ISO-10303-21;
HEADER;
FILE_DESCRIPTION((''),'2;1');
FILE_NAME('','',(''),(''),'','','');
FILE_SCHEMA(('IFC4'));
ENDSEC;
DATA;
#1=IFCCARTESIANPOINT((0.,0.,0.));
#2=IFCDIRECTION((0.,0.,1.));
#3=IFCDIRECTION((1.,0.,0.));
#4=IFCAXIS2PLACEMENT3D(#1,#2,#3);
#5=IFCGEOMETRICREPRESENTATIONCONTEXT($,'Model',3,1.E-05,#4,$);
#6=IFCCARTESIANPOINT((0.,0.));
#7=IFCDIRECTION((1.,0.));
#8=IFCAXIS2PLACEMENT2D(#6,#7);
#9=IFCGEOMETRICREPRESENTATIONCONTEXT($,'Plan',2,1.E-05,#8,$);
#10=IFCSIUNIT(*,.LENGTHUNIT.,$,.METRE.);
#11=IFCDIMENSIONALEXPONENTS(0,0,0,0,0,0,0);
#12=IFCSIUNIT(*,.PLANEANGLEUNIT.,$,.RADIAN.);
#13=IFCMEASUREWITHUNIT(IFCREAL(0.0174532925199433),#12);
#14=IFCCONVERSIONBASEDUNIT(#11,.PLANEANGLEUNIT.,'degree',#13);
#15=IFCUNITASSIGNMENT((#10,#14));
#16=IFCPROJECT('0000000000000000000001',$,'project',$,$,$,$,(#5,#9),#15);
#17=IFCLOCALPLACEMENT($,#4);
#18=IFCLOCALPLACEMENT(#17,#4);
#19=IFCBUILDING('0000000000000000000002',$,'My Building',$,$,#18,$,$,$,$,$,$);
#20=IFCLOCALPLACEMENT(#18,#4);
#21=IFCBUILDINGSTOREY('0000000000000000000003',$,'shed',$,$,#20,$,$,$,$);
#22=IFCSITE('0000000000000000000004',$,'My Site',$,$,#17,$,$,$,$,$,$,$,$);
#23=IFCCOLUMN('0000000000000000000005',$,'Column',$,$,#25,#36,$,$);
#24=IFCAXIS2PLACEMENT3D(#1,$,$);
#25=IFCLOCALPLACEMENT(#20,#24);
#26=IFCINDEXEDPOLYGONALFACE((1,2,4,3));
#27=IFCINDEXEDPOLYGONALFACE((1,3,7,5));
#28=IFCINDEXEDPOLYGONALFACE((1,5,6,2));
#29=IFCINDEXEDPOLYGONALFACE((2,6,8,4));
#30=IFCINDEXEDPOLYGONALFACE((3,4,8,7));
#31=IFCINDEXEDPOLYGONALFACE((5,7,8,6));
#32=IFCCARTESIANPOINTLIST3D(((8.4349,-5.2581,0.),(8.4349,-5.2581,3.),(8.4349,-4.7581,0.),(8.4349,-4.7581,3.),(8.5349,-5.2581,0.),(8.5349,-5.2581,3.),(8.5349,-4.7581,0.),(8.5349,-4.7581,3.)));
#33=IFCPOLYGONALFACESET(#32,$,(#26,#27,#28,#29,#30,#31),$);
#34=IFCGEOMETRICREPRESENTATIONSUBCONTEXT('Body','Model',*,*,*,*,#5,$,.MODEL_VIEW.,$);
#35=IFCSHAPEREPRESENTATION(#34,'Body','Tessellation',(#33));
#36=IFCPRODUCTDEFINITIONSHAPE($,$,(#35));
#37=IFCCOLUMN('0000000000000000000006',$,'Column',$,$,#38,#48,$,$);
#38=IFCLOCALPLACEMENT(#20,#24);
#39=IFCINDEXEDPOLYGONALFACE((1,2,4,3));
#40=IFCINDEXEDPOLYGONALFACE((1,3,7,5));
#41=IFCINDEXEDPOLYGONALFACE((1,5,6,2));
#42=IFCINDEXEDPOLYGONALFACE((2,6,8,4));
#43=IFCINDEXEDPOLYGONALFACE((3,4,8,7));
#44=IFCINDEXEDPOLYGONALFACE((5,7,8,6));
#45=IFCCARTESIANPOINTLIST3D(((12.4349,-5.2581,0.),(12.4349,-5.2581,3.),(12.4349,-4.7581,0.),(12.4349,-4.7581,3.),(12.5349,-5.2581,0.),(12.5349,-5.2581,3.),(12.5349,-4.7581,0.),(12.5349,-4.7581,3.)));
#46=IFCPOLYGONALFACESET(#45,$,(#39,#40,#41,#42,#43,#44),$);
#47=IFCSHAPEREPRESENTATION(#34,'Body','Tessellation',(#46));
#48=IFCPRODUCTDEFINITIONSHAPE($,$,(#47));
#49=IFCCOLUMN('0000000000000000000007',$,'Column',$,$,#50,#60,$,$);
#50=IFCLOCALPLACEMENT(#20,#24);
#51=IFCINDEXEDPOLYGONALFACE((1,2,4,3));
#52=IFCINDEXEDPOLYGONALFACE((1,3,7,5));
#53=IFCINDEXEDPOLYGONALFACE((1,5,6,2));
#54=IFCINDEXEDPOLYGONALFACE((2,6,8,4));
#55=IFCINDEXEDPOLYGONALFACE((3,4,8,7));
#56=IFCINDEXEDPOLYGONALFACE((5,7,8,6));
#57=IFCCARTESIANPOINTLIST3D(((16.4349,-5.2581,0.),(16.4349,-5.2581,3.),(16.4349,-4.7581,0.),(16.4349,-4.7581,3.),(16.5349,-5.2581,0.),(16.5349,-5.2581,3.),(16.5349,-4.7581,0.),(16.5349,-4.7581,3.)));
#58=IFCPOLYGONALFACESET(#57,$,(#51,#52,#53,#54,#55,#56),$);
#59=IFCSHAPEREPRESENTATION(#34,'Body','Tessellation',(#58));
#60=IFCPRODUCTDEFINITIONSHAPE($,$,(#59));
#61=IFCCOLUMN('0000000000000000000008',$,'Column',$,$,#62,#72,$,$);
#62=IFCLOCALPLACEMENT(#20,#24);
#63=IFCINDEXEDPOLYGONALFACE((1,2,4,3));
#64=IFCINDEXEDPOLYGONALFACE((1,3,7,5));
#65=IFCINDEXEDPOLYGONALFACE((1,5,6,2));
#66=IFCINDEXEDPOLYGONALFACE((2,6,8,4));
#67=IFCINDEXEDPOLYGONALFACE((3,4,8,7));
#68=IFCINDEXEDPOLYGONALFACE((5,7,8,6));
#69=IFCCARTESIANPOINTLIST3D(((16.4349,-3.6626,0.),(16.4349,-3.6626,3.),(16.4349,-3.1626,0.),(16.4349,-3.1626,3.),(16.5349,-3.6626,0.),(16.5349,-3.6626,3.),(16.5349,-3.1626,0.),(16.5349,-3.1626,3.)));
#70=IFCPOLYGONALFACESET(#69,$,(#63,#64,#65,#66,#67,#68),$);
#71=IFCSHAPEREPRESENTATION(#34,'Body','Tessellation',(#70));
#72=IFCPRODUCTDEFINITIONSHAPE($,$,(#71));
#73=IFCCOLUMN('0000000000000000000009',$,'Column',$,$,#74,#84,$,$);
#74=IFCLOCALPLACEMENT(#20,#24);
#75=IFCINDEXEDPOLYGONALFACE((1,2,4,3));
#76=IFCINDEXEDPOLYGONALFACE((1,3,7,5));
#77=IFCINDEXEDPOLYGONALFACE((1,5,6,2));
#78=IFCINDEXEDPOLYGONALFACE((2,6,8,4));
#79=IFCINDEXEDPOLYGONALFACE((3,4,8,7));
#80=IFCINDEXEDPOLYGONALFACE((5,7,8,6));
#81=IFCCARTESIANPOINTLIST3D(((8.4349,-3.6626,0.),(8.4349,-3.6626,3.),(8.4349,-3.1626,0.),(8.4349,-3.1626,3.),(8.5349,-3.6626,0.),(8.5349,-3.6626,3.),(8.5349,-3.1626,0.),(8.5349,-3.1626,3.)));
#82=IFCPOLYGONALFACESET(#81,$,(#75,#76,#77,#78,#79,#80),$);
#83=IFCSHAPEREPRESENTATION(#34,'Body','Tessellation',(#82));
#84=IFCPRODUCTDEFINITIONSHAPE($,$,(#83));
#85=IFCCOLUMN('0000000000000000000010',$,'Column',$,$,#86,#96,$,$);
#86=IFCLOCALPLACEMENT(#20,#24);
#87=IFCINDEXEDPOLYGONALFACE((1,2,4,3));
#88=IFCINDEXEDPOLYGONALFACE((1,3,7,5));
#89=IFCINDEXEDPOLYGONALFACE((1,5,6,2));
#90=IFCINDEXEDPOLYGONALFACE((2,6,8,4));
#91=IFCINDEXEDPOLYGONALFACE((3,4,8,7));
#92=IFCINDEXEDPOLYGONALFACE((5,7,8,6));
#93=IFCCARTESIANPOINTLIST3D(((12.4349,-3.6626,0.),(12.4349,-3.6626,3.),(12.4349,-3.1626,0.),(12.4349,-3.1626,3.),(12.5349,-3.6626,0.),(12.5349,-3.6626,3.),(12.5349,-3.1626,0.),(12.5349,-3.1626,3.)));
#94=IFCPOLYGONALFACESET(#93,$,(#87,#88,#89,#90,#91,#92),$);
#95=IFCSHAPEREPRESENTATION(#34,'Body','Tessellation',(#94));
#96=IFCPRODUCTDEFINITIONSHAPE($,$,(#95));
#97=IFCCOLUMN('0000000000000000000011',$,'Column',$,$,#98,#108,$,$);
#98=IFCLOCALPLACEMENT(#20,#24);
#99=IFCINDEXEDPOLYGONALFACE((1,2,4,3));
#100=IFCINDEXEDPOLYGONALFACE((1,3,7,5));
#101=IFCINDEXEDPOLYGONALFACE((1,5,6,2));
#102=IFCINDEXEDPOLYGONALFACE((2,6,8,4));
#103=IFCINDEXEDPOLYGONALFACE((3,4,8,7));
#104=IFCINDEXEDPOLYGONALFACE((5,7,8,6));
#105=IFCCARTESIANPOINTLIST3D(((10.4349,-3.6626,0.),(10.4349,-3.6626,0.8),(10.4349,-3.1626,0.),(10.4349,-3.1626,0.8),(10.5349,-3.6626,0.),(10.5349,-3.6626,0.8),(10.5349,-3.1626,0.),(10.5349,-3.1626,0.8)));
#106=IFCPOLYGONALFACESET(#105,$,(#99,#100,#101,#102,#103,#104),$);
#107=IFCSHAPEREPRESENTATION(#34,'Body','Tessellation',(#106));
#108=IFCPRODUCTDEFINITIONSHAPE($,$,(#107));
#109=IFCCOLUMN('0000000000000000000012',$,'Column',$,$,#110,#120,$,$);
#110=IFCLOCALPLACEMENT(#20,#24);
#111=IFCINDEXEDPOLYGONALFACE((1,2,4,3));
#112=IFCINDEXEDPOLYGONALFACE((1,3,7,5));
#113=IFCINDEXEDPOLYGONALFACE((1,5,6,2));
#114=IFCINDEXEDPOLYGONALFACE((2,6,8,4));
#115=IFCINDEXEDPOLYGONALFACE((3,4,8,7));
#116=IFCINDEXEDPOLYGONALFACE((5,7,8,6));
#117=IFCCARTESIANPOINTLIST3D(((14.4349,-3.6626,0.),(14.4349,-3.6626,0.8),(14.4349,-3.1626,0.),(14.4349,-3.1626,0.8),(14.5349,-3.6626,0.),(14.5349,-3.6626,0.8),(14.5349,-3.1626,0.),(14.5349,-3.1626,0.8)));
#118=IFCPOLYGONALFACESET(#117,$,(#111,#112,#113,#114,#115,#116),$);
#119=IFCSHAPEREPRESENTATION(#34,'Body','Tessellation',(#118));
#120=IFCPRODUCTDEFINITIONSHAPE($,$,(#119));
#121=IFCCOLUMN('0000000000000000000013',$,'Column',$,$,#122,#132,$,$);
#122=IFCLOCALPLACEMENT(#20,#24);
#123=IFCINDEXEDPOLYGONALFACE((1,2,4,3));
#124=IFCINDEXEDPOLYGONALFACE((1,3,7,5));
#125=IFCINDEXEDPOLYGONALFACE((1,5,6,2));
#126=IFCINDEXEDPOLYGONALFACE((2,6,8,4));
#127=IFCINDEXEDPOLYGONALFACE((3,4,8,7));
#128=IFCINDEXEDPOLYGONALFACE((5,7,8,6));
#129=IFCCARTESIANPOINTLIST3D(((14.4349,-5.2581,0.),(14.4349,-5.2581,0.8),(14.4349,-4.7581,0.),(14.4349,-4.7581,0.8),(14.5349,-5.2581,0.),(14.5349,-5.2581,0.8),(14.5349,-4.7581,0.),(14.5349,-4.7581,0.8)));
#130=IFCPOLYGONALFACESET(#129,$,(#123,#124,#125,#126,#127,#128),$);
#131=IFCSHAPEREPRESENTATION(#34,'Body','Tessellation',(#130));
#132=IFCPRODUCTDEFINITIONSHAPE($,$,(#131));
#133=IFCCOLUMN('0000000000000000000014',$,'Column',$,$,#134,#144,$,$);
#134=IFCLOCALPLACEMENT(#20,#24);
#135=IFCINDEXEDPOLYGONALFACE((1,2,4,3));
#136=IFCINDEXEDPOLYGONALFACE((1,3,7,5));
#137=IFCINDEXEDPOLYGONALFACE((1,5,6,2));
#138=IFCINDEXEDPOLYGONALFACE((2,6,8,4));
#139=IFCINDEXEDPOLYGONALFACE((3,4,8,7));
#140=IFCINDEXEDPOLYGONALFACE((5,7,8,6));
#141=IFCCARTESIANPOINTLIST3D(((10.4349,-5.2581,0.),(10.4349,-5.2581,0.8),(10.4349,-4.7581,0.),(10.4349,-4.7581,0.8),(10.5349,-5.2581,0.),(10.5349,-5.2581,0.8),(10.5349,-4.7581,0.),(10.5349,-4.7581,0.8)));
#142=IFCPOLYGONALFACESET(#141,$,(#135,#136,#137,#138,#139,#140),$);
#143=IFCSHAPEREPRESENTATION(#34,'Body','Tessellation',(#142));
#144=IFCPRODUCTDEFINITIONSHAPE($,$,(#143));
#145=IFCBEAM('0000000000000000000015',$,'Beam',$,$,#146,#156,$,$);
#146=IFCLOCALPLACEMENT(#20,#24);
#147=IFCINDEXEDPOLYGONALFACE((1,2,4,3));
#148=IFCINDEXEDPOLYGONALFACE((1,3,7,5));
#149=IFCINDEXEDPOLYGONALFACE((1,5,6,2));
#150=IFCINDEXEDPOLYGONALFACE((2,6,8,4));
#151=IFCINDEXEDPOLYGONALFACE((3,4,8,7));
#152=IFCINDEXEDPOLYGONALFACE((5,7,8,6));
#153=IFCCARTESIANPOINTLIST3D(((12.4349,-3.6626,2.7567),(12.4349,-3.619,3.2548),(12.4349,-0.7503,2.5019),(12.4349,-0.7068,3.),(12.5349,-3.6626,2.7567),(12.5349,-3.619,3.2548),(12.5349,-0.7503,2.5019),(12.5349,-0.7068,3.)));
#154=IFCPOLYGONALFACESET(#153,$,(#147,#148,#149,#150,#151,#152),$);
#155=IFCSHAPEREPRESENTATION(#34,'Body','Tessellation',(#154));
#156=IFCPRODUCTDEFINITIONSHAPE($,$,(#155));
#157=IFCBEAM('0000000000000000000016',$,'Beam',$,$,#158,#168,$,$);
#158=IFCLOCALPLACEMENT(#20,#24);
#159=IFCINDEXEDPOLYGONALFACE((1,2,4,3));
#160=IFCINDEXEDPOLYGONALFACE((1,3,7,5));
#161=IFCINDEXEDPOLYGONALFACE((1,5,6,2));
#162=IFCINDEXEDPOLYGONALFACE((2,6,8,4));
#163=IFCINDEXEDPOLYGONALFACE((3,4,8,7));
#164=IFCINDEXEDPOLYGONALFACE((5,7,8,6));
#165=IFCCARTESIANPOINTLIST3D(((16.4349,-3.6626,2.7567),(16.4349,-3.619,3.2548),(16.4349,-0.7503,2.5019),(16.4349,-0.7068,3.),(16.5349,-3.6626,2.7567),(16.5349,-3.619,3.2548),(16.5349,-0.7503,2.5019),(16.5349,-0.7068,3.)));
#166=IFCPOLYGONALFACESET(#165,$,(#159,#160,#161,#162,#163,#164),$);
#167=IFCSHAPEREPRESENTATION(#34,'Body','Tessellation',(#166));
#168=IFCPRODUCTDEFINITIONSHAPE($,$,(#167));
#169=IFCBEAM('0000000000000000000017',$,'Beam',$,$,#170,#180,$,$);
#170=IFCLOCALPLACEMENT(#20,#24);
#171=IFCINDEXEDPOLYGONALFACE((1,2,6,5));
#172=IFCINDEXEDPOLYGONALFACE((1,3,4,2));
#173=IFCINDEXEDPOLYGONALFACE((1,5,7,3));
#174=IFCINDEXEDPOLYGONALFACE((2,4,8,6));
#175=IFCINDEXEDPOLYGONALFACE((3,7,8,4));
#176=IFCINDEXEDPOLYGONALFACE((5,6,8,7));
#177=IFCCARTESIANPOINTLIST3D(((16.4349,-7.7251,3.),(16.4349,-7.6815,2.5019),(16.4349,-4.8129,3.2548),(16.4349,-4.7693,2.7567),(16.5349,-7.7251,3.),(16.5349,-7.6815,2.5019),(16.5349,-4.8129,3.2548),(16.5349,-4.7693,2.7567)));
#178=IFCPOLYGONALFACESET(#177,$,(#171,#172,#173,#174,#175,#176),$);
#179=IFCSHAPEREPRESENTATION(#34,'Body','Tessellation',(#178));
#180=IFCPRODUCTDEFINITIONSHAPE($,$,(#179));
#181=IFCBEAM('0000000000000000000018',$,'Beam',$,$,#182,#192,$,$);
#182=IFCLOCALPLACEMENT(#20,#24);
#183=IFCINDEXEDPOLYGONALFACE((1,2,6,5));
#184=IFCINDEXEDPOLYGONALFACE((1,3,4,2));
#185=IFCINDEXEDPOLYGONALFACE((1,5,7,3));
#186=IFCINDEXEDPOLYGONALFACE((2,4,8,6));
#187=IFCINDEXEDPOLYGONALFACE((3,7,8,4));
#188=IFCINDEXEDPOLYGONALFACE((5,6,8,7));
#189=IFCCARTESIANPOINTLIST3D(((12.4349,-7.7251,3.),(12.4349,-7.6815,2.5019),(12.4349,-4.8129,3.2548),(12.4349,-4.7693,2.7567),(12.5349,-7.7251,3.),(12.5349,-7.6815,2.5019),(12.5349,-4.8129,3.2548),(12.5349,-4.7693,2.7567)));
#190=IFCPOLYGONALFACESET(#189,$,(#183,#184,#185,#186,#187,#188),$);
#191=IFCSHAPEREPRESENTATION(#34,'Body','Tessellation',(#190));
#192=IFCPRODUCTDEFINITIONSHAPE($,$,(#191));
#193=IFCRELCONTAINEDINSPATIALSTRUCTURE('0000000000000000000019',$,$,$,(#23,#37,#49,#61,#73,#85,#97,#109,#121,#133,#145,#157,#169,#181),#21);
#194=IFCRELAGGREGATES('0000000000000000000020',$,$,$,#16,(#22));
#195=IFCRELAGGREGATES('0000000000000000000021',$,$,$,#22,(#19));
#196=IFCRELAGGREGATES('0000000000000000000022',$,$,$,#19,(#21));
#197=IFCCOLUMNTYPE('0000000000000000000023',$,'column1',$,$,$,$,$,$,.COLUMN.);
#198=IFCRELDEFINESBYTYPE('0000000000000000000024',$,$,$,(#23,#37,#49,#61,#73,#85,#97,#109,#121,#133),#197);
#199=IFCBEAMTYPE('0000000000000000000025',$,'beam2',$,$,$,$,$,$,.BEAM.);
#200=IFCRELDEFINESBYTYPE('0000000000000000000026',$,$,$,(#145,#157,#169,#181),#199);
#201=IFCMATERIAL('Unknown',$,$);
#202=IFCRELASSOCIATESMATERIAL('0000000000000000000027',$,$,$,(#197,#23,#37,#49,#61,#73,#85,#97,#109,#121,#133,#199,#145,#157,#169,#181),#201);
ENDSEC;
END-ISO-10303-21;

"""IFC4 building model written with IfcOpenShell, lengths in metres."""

from ifc_helpers import new_model, entity, si_unit, converted_unit, frame, origin_with_axes, origin_2d_with_axis, place, context, subcontext, project, spatial, rectangle, extrude, material, material_profile, profile_set, profile_usage, type_object, element, save


model = new_model("IFC4")

# Units and contexts
model_context = context("Model", 3, precision=1e-05, world=origin_with_axes())
plan_context = context("Plan", 2, precision=1e-05, world=origin_2d_with_axis())
body_context = subcontext(model_context, "Body", "Model", "MODEL_VIEW")
ifc_project = project(units=[si_unit("LENGTHUNIT", "METRE"), converted_unit("PLANEANGLEUNIT", "degree", entity("IfcReal", 0.0174532925199433), si_unit("PLANEANGLEUNIT", "RADIAN"), dimensions=[0, 0, 0, 0, 0, 0, 0])], contexts=[model_context, plan_context])

# Site, building, storey
site_placement = place(None, origin_with_axes())
site = spatial("IfcSite", under=ifc_project, at=site_placement, Name="My Site")
building_placement = place(site_placement, origin_with_axes())
building = spatial("IfcBuilding", under=site, at=building_placement, Name="My Building")
storey_placement = place(building_placement, origin_with_axes())
storey = spatial("IfcBuildingStorey", under=building, at=storey_placement, Name="shed")

# Columns
ifc_material = material(Name="Unknown")
ifc_material_profile_1 = material_profile(ifc_material, rectangle(XDim=0.1, YDim=0.5))
ifc_profile_set_1 = profile_set([ifc_material_profile_1])
ifc_profile_usage_1 = profile_usage(ifc_profile_set_1, cardinal=5)
column_type = type_object("IfcColumnType", Name="column1", PredefinedType="COLUMN", material=ifc_profile_set_1)
column_1_placement = place(storey_placement, frame((8.4849, -5.0081, 0.0), z_axis=(0.0, 0.0, 1.0), x_axis=(1.0, 0.0, 0.0)))
element("IfcColumn", 1, at=column_1_placement, inside=storey, type_object=column_type, material=ifc_profile_usage_1, Name="Column", context=body_context, shape_type="SweptSolid", body=[
    extrude(rectangle(XDim=0.1, YDim=0.5), origin_with_axes(), (0.0, 0.0, 1.0), 3.0),
])
ifc_profile_usage_2 = profile_usage(ifc_profile_set_1, cardinal=5)
column_2_placement = place(storey_placement, frame((12.4849, -5.0081, 0.0), z_axis=(0.0, 0.0, 1.0), x_axis=(1.0, 0.0, 0.0)))
element("IfcColumn", 2, at=column_2_placement, inside=storey, type_object=column_type, material=ifc_profile_usage_2, Name="Column", context=body_context, shape_type="SweptSolid", body=[
    extrude(rectangle(XDim=0.1, YDim=0.5), origin_with_axes(), (0.0, 0.0, 1.0), 3.0),
])
ifc_profile_usage_3 = profile_usage(ifc_profile_set_1, cardinal=5)
column_3_placement = place(storey_placement, frame((16.4849, -5.0081, 0.0), z_axis=(0.0, 0.0, 1.0), x_axis=(1.0, 0.0, 0.0)))
element("IfcColumn", 3, at=column_3_placement, inside=storey, type_object=column_type, material=ifc_profile_usage_3, Name="Column", context=body_context, shape_type="SweptSolid", body=[
    extrude(rectangle(XDim=0.1, YDim=0.5), origin_with_axes(), (0.0, 0.0, 1.0), 3.0),
])
ifc_profile_usage_4 = profile_usage(ifc_profile_set_1, cardinal=5)
column_4_placement = place(storey_placement, frame((16.4849, -3.4126, 0.0), z_axis=(0.0, 0.0, 1.0), x_axis=(-1.0, 0.0, 0.0)))
element("IfcColumn", 4, at=column_4_placement, inside=storey, type_object=column_type, material=ifc_profile_usage_4, Name="Column", context=body_context, shape_type="SweptSolid", body=[
    extrude(rectangle(XDim=0.1, YDim=0.5), origin_with_axes(), (0.0, 0.0, 1.0), 3.0),
])
ifc_profile_usage_5 = profile_usage(ifc_profile_set_1, cardinal=5)
column_5_placement = place(storey_placement, frame((8.4849, -3.4126, 0.0), z_axis=(0.0, 0.0, 1.0), x_axis=(-1.0, 0.0, 0.0)))
element("IfcColumn", 5, at=column_5_placement, inside=storey, type_object=column_type, material=ifc_profile_usage_5, Name="Column", context=body_context, shape_type="SweptSolid", body=[
    extrude(rectangle(XDim=0.1, YDim=0.5), origin_with_axes(), (0.0, 0.0, 1.0), 3.0),
])
ifc_profile_usage_6 = profile_usage(ifc_profile_set_1, cardinal=5)
column_6_placement = place(storey_placement, frame((12.4849, -3.4126, 0.0), z_axis=(0.0, 0.0, 1.0), x_axis=(-1.0, 0.0, 0.0)))
element("IfcColumn", 6, at=column_6_placement, inside=storey, type_object=column_type, material=ifc_profile_usage_6, Name="Column", context=body_context, shape_type="SweptSolid", body=[
    extrude(rectangle(XDim=0.1, YDim=0.5), origin_with_axes(), (0.0, 0.0, 1.0), 3.0),
])
ifc_profile_usage_7 = profile_usage(ifc_profile_set_1, cardinal=5)
column_7_placement = place(storey_placement, frame((10.4849, -3.4126, 0.0), z_axis=(0.0, 0.0, 1.0), x_axis=(-1.0, 0.0, 0.0)))
element("IfcColumn", 7, at=column_7_placement, inside=storey, type_object=column_type, material=ifc_profile_usage_7, Name="Column", context=body_context, shape_type="SweptSolid", body=[
    extrude(rectangle(XDim=0.1, YDim=0.5), origin_with_axes(), (0.0, 0.0, 1.0), 0.8),
])
ifc_profile_usage_8 = profile_usage(ifc_profile_set_1, cardinal=5)
column_8_placement = place(storey_placement, frame((14.4849, -3.4126, 0.0), z_axis=(0.0, 0.0, 1.0), x_axis=(-1.0, 0.0, 0.0)))
element("IfcColumn", 8, at=column_8_placement, inside=storey, type_object=column_type, material=ifc_profile_usage_8, Name="Column", context=body_context, shape_type="SweptSolid", body=[
    extrude(rectangle(XDim=0.1, YDim=0.5), origin_with_axes(), (0.0, 0.0, 1.0), 0.8),
])
ifc_profile_usage_9 = profile_usage(ifc_profile_set_1, cardinal=5)
column_9_placement = place(storey_placement, frame((14.4849, -5.0081, 0.0), z_axis=(0.0, 0.0, 1.0), x_axis=(-1.0, 0.0, 0.0)))
element("IfcColumn", 9, at=column_9_placement, inside=storey, type_object=column_type, material=ifc_profile_usage_9, Name="Column", context=body_context, shape_type="SweptSolid", body=[
    extrude(rectangle(XDim=0.1, YDim=0.5), origin_with_axes(), (0.0, 0.0, 1.0), 0.8),
])
ifc_profile_usage_10 = profile_usage(ifc_profile_set_1, cardinal=5)
column_10_placement = place(storey_placement, frame((10.4849, -5.0081, 0.0), z_axis=(0.0, 0.0, 1.0), x_axis=(-1.0, 0.0, 0.0)))
element("IfcColumn", 10, at=column_10_placement, inside=storey, type_object=column_type, material=ifc_profile_usage_10, Name="Column", context=body_context, shape_type="SweptSolid", body=[
    extrude(rectangle(XDim=0.1, YDim=0.5), origin_with_axes(), (0.0, 0.0, 1.0), 0.8),
])

# Beams
ifc_material_profile_2 = material_profile(ifc_material, rectangle(XDim=0.1, YDim=0.5))
ifc_profile_set_2 = profile_set([ifc_material_profile_2])
ifc_profile_usage_11 = profile_usage(ifc_profile_set_2, cardinal=8)
beam_type = type_object("IfcBeamType", Name="beam2", PredefinedType="BEAM", material=ifc_profile_set_2)
beam_1_placement = place(storey_placement, frame((12.4849, -0.7068, 3.0), z_axis=(0.0, -0.996195, 0.087156), x_axis=(1.0, 0.0, 0.0)))
element("IfcBeam", 11, at=beam_1_placement, inside=storey, type_object=beam_type, material=ifc_profile_usage_11, Name="Beam", context=body_context, shape_type="SweptSolid", body=[
    extrude(rectangle(XDim=0.1, YDim=0.5), frame((0.0, -0.25, 0.0), z_axis=(0.0, 0.0, 1.0), x_axis=(1.0, 0.0, 0.0)), (0.0, 0.0, 1.0), 2.9234),
])
ifc_profile_usage_12 = profile_usage(ifc_profile_set_2, cardinal=8)
beam_2_placement = place(storey_placement, frame((16.4849, -0.7068, 3.0), z_axis=(0.0, -0.996195, 0.087156), x_axis=(1.0, 0.0, 0.0)))
element("IfcBeam", 12, at=beam_2_placement, inside=storey, type_object=beam_type, material=ifc_profile_usage_12, Name="Beam", context=body_context, shape_type="SweptSolid", body=[
    extrude(rectangle(XDim=0.1, YDim=0.5), frame((0.0, -0.25, 0.0), z_axis=(0.0, 0.0, 1.0), x_axis=(1.0, 0.0, 0.0)), (0.0, 0.0, 1.0), 2.9234),
])
ifc_profile_usage_13 = profile_usage(ifc_profile_set_2, cardinal=8)
beam_3_placement = place(storey_placement, frame((16.4849, -7.7251, 3.0), z_axis=(0.0, 0.996195, 0.087156), x_axis=(-1.0, 0.0, 0.0)))
element("IfcBeam", 13, at=beam_3_placement, inside=storey, type_object=beam_type, material=ifc_profile_usage_13, Name="Beam", context=body_context, shape_type="SweptSolid", body=[
    extrude(rectangle(XDim=0.1, YDim=0.5), frame((0.0, -0.25, 0.0), z_axis=(0.0, 0.0, 1.0), x_axis=(1.0, 0.0, 0.0)), (0.0, 0.0, 1.0), 2.9234),
])
ifc_profile_usage_14 = profile_usage(ifc_profile_set_2, cardinal=8)
beam_4_placement = place(storey_placement, frame((12.4849, -7.7251, 3.0), z_axis=(0.0, 0.996195, 0.087156), x_axis=(-1.0, 0.0, 0.0)))
element("IfcBeam", 14, at=beam_4_placement, inside=storey, type_object=beam_type, material=ifc_profile_usage_14, Name="Beam", context=body_context, shape_type="SweptSolid", body=[
    extrude(rectangle(XDim=0.1, YDim=0.5), frame((0.0, -0.25, 0.0), z_axis=(0.0, 0.0, 1.0), x_axis=(1.0, 0.0, 0.0)), (0.0, 0.0, 1.0), 2.9234),
])

save(model, "model.ifc")
